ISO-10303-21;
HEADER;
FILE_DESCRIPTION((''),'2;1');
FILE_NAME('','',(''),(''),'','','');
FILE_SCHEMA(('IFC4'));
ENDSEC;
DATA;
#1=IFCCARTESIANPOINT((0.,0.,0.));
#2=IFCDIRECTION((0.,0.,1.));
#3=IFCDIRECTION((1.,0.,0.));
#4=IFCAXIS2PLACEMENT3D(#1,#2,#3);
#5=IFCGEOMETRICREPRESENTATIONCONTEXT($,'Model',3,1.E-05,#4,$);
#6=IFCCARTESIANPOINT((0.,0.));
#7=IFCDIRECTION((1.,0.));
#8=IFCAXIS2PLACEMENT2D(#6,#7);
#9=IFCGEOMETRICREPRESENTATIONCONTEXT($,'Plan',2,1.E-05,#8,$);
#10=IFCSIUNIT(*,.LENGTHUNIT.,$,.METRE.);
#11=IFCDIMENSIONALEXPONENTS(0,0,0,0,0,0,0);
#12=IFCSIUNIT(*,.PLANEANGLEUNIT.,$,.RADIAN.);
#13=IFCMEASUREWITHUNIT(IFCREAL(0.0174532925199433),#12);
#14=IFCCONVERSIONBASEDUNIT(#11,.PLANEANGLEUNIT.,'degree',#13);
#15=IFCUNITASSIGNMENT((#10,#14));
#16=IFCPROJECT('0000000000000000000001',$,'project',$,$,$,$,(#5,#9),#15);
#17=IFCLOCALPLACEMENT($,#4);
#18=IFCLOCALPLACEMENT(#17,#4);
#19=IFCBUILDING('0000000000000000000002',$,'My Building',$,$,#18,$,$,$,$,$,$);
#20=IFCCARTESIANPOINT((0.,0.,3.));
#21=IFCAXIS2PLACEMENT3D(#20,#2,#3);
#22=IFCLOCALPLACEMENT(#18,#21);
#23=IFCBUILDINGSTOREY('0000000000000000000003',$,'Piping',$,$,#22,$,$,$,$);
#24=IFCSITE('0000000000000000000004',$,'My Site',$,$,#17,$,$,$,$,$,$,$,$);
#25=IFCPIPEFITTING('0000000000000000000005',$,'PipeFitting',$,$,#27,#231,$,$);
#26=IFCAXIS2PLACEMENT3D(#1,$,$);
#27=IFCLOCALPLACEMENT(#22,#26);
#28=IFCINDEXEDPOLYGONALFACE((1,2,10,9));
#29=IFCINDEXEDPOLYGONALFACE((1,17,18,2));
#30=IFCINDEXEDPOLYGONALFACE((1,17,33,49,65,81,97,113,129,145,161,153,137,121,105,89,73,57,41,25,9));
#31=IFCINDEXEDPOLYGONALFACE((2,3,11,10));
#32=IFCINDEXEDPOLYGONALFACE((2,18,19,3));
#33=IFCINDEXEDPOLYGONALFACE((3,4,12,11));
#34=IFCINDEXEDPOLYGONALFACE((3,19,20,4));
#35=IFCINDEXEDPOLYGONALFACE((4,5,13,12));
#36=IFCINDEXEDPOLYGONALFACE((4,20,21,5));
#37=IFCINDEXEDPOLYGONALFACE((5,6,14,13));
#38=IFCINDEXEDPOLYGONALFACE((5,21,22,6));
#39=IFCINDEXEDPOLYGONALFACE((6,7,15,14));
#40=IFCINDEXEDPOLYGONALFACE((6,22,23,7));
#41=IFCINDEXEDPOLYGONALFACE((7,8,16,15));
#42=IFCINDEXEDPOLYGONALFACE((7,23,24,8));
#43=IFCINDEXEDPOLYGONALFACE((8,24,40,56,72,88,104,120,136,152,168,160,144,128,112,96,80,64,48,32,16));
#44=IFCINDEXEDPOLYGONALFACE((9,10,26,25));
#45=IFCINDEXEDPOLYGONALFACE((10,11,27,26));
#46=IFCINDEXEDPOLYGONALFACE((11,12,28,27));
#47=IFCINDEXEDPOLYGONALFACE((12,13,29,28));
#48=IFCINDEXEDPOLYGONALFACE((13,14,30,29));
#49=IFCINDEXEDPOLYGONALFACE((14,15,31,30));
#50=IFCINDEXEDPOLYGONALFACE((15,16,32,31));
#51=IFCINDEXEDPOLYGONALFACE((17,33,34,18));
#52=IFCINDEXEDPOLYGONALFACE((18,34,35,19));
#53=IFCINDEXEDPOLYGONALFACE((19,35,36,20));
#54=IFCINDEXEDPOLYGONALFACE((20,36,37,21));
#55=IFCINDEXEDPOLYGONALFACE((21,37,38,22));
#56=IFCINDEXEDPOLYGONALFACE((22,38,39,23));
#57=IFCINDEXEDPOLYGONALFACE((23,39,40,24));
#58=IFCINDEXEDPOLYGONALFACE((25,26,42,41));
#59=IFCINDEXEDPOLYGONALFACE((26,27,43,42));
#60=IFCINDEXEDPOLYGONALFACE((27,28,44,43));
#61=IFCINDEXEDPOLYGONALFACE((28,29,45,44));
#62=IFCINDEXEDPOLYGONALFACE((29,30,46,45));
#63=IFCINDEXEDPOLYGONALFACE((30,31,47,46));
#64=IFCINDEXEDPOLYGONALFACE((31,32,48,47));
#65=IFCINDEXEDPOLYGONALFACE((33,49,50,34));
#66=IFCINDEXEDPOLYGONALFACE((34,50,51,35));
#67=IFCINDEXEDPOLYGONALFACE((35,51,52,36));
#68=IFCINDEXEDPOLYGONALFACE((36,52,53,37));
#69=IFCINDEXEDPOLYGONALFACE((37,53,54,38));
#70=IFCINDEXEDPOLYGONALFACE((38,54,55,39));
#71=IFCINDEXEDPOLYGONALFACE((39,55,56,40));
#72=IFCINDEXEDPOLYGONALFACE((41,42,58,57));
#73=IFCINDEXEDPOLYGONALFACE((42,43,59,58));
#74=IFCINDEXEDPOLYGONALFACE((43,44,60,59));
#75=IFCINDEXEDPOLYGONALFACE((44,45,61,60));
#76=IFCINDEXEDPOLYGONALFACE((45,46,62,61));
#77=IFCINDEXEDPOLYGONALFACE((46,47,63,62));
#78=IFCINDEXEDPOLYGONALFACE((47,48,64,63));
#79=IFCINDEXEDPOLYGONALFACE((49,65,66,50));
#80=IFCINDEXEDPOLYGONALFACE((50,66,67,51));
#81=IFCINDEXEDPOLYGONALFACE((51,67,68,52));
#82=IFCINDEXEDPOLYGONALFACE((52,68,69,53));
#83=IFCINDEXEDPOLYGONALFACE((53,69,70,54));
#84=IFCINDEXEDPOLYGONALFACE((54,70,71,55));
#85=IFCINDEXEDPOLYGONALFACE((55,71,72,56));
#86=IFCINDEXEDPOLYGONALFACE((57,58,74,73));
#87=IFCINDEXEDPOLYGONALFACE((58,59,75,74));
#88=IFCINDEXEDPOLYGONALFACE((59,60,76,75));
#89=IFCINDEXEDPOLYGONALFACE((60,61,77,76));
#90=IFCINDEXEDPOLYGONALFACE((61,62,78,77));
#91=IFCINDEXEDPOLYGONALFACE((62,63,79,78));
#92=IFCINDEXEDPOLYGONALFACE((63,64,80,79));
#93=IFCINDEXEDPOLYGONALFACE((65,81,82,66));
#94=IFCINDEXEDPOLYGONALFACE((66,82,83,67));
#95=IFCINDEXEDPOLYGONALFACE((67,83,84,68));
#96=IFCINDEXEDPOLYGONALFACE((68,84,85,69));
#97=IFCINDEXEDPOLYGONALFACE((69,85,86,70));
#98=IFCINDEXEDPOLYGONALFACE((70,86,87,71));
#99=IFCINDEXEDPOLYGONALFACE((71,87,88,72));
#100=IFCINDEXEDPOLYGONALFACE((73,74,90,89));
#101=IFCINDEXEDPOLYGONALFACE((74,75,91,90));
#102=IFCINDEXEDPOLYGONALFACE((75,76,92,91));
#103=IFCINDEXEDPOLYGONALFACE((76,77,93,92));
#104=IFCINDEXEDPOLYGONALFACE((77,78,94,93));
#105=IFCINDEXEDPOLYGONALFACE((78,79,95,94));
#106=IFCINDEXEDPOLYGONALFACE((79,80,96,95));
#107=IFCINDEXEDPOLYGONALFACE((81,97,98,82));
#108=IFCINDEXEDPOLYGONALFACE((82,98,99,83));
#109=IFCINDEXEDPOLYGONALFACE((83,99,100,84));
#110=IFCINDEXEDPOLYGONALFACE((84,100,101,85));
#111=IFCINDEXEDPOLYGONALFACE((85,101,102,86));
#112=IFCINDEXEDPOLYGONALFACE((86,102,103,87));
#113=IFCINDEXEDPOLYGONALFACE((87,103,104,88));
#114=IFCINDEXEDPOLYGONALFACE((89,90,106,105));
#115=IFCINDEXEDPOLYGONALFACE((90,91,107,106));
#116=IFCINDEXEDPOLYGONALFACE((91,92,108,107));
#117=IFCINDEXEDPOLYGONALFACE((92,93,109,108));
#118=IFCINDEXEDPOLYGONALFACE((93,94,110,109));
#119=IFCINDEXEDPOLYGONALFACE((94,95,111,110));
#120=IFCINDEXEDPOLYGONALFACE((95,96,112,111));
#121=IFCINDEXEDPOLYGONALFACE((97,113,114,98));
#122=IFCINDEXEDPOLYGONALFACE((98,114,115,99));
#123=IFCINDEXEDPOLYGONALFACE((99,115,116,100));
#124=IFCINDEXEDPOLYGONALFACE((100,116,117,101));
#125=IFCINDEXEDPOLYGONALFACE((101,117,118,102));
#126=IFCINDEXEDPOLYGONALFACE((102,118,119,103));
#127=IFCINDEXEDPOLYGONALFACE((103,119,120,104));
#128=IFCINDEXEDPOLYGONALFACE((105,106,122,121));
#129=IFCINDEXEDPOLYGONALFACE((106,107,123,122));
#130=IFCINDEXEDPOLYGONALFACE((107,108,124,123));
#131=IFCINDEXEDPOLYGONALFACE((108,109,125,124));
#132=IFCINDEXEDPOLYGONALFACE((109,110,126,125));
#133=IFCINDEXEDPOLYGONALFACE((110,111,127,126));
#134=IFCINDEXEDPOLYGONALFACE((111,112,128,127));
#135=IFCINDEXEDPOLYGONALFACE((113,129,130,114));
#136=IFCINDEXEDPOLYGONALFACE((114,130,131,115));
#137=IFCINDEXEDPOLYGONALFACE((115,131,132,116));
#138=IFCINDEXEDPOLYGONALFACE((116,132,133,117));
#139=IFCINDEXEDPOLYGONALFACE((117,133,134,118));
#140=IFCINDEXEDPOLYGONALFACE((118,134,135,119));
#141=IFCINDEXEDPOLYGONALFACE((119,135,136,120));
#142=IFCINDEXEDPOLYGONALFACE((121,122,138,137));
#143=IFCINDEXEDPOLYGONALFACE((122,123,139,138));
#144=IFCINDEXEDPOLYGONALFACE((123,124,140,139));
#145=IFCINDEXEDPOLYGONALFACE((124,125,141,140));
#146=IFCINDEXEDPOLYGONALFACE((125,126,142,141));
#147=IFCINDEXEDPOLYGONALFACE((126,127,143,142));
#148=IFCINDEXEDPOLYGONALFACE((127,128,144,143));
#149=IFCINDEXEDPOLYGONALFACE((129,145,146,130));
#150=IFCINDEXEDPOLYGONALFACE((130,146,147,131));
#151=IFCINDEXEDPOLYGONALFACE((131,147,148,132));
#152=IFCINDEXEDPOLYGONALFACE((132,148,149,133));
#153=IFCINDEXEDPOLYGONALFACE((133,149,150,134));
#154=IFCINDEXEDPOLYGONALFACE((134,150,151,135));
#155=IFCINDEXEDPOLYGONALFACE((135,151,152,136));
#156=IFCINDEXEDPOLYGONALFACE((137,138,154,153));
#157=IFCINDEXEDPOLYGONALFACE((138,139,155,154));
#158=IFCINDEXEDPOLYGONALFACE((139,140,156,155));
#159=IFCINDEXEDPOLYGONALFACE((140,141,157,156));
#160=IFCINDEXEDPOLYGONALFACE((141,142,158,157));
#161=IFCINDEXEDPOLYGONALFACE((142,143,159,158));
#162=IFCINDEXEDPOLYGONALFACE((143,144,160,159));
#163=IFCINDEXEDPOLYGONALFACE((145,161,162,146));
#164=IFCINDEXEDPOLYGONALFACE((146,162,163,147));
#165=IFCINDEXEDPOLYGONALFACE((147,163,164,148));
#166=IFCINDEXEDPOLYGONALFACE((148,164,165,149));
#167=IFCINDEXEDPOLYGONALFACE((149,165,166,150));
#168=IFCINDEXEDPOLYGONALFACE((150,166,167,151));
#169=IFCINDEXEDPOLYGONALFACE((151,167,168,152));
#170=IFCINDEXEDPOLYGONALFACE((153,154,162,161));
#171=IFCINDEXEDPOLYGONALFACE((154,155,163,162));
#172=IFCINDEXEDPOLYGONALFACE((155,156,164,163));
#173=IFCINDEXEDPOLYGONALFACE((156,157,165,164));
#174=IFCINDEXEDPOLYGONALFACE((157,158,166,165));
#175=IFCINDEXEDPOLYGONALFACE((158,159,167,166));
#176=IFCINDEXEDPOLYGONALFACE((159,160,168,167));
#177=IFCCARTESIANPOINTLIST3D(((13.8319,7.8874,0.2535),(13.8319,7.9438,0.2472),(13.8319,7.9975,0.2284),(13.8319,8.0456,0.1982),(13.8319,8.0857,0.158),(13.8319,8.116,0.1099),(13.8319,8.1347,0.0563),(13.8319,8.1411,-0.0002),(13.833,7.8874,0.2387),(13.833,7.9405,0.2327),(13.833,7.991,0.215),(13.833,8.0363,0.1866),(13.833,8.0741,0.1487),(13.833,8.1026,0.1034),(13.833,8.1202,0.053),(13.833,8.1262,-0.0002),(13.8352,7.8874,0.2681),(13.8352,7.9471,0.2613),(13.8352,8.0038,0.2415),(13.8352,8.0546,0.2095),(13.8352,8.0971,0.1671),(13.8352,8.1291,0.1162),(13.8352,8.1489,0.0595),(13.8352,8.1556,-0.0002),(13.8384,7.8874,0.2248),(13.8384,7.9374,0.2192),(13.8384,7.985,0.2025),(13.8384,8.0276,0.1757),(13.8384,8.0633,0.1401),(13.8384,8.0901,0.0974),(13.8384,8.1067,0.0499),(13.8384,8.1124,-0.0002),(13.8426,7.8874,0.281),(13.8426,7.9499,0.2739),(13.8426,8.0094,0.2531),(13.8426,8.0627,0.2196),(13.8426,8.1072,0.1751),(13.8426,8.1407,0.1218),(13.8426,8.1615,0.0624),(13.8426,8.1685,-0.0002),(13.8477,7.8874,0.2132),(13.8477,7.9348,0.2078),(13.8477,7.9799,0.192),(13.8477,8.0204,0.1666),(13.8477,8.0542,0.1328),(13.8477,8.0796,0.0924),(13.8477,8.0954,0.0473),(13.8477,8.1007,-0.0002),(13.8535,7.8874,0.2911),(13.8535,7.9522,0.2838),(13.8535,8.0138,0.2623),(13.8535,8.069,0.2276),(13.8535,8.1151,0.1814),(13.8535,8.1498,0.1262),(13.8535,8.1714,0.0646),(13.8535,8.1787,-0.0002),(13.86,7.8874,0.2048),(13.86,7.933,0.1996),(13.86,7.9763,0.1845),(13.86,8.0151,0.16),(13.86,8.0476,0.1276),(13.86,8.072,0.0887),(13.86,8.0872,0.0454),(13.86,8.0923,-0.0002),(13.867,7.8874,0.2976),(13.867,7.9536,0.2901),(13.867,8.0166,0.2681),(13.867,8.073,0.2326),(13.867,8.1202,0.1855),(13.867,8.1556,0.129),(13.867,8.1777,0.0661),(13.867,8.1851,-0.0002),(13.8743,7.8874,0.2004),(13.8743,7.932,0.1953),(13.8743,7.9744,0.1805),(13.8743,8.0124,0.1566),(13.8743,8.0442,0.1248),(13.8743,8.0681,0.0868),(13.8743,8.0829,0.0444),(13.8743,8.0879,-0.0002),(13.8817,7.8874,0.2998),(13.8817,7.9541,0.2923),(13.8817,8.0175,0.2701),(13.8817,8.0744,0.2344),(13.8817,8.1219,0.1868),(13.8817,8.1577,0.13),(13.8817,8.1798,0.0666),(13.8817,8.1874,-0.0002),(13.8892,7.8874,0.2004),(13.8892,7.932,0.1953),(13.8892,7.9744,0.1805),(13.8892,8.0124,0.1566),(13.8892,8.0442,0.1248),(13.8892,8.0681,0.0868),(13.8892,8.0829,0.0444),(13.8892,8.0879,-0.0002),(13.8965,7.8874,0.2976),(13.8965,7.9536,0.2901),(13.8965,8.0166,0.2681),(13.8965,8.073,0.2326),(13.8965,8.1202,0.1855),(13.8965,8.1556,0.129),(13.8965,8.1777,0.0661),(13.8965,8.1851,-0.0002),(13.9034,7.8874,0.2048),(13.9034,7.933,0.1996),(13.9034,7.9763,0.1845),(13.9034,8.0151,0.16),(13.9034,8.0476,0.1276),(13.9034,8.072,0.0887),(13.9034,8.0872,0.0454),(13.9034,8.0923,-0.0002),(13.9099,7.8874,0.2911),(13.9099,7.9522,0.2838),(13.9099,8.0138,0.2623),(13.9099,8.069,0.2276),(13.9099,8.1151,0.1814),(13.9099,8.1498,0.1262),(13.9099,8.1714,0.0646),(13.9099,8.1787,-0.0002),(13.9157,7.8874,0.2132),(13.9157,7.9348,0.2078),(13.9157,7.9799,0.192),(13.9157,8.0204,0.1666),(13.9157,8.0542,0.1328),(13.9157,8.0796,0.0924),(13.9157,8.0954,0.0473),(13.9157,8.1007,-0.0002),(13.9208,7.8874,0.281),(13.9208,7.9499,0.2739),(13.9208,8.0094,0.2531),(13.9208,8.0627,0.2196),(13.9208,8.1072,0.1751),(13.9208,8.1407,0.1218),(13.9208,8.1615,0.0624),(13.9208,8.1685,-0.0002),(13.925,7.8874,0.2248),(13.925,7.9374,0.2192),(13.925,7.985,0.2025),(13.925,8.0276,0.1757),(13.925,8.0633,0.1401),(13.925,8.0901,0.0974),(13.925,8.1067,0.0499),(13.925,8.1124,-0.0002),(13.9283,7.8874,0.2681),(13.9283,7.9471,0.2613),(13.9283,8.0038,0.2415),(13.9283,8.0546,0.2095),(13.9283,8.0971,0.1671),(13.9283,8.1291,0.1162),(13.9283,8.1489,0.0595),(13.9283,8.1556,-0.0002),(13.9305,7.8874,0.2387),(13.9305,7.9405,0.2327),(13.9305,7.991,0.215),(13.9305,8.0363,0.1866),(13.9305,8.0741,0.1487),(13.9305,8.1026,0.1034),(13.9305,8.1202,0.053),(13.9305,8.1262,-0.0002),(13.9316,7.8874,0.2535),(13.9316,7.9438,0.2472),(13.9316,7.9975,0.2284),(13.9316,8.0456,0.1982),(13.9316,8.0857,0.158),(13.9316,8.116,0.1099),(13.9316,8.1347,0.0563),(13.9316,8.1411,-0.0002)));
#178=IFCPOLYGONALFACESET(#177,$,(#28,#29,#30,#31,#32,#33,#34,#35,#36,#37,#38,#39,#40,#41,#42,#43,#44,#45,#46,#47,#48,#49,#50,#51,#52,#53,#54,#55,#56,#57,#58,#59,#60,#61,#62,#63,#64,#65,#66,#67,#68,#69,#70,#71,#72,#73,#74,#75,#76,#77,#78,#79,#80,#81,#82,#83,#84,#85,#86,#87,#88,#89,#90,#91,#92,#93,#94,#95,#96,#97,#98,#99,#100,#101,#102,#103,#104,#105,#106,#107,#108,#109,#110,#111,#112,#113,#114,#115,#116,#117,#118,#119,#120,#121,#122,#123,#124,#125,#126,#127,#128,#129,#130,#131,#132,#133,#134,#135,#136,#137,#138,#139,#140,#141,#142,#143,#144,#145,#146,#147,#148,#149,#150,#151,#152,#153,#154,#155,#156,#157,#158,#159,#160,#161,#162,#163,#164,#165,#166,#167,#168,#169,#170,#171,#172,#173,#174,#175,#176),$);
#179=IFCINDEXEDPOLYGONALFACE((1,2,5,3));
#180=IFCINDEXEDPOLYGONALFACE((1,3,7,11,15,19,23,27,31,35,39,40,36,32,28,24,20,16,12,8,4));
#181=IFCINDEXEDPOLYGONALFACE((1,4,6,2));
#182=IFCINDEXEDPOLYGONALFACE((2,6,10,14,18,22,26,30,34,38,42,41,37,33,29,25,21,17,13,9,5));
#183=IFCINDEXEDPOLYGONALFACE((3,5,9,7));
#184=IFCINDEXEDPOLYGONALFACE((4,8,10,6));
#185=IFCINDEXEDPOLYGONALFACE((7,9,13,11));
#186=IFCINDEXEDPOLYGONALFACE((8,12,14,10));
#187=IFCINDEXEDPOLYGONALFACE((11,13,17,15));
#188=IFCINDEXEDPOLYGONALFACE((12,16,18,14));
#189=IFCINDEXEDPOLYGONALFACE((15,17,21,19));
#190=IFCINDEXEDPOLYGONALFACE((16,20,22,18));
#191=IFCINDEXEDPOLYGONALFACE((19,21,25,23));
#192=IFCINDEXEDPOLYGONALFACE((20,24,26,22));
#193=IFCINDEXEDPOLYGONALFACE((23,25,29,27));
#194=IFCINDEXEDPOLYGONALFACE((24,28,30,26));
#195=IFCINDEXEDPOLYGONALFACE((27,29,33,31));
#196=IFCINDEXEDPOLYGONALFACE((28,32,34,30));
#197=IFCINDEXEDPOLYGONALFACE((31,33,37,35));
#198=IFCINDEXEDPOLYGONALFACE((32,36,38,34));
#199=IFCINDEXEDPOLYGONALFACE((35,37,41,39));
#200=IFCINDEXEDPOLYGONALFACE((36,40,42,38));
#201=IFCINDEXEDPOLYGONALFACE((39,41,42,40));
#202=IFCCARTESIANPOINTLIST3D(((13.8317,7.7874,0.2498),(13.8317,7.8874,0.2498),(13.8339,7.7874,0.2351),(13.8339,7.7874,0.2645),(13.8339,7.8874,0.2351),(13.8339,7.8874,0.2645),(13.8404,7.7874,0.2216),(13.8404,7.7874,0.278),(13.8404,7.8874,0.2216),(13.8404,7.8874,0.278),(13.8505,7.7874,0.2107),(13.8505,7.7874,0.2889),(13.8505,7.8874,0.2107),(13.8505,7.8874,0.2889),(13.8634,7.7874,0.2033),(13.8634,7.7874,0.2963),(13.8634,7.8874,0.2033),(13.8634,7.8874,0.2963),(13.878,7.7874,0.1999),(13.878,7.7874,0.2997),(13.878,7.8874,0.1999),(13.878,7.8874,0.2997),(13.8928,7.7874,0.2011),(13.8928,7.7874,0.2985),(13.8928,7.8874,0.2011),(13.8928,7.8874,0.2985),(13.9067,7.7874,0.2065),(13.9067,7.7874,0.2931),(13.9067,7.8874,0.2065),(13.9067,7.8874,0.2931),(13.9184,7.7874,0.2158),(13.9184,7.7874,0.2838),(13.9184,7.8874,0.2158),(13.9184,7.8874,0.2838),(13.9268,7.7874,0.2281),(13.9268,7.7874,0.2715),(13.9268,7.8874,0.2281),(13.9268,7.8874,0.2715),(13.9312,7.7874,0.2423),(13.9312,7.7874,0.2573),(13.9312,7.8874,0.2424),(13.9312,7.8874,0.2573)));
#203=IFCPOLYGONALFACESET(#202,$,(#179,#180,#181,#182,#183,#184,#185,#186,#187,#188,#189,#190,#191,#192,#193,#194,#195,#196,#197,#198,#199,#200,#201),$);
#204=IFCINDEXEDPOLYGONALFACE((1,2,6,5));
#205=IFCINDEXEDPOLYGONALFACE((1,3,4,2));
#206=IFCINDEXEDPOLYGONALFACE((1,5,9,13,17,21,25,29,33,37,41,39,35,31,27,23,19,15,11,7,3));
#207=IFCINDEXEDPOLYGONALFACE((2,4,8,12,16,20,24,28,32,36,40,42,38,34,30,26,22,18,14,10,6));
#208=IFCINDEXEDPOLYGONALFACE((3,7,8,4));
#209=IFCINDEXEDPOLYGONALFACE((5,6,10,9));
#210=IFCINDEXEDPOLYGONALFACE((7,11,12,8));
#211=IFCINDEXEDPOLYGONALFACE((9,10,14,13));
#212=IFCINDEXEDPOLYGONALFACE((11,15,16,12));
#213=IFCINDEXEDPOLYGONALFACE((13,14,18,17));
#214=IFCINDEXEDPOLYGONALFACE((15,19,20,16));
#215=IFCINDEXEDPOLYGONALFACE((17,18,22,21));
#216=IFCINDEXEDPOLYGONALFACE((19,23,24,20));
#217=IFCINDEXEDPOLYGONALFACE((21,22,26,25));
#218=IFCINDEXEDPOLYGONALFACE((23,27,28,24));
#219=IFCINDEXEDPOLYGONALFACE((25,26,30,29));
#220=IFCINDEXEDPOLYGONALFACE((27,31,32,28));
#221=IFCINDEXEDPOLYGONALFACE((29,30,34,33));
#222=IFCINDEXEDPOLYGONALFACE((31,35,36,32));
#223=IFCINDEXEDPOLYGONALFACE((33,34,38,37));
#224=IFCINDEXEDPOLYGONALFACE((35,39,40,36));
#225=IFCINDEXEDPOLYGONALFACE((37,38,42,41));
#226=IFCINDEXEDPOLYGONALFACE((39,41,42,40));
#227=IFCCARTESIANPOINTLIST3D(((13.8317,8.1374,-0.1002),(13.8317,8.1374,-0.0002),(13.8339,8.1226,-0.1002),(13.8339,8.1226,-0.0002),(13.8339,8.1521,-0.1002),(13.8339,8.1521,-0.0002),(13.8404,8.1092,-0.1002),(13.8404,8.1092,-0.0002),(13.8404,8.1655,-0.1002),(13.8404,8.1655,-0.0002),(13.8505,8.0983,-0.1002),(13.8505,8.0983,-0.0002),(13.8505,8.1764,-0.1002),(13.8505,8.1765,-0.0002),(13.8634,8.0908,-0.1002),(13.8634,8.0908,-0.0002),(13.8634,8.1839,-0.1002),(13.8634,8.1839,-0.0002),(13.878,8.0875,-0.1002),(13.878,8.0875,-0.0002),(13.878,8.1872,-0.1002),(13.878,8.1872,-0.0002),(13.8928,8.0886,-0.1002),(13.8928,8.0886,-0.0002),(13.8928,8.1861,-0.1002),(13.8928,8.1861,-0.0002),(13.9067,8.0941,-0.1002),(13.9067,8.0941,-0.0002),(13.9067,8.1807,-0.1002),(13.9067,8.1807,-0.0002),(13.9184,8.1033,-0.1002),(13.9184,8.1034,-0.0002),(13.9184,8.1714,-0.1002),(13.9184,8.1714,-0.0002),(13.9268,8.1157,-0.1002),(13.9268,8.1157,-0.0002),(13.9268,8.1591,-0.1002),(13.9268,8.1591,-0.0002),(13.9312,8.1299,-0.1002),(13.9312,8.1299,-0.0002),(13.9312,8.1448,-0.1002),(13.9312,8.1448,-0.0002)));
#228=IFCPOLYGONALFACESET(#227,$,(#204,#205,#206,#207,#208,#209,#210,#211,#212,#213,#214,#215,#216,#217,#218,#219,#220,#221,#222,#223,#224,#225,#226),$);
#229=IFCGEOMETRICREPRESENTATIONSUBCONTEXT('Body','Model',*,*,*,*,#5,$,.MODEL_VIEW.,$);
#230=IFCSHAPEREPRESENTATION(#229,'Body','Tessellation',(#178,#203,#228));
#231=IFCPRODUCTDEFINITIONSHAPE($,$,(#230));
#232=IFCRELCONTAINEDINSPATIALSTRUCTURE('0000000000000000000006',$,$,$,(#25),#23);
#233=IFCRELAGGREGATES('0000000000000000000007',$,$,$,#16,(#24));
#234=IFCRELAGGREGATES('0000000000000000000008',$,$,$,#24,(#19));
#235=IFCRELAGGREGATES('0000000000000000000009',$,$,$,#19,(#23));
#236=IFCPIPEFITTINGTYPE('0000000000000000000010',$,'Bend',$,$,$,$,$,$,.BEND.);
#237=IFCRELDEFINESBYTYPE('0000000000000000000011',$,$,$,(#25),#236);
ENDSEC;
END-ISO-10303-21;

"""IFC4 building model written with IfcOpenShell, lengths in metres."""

from ifc_helpers import new_model, entity, si_unit, converted_unit, frame, origin_with_axes, origin_2d_with_axis, place, context, subcontext, project, spatial, circle, extrude, source, transform, mapped, type_object, type_shapes, element, save


model = new_model("IFC4")

# Units and contexts
model_context = context("Model", 3, precision=1e-05, world=origin_with_axes())
plan_context = context("Plan", 2, precision=1e-05, world=origin_2d_with_axis())
body_context = subcontext(model_context, "Body", "Model", "MODEL_VIEW")
ifc_project = project(units=[si_unit("LENGTHUNIT", "METRE"), converted_unit("PLANEANGLEUNIT", "degree", entity("IfcReal", 0.0174532925199433), si_unit("PLANEANGLEUNIT", "RADIAN"), dimensions=[0, 0, 0, 0, 0, 0, 0])], contexts=[model_context, plan_context])

# Site, building, storey
site_placement = place(None, origin_with_axes())
site = spatial("IfcSite", under=ifc_project, at=site_placement, Name="My Site")
building_placement = place(site_placement, origin_with_axes())
building = spatial("IfcBuilding", under=site, at=building_placement, Name="My Building")
storey_placement = place(building_placement, frame((0.0, 0.0, 3.0), z_axis=(0.0, 0.0, 1.0), x_axis=(1.0, 0.0, 0.0)))
storey = spatial("IfcBuildingStorey", under=building, at=storey_placement, Name="Piping")

# Pipe fitting
pipe_fitting_type_1 = type_object("IfcPipeFittingType", Name="Bend", PredefinedType="BEND")
shared_shape = source(origin_with_axes(), body_context, "Body", "SolidModel", [
    entity("IfcSweptDiskSolid", entity("IfcIndexedPolyCurve", entity("IfcCartesianPointList3D", [[0.0, 0.0, 0.1], [0.0, -0.0732, 0.2768], [0.0, -0.25, 0.35]]), [entity("IfcArcIndex", [1, 2, 3])]), 0.05),
    extrude(circle(Radius=0.05), origin_with_axes(), (0.0, 0.0, 1.0), 0.1),
    extrude(circle(Radius=0.05), frame((0.0, -0.25, 0.35), z_axis=(0.0, -1.0, -0.00003), x_axis=(1.0, 0.0, 0.0)), (0.0, 0.0, 1.0), 0.1),
])
type_shapes(pipe_fitting_type_1, [shared_shape])
for number, where, z_axis, x_axis, name in (
    (1, (13.8817, 7.7874, 0.2498), (0.0, 1.0, 0.000008), (-1.0, 0.0, 0.0), "PipeFitting"),
):
    element("IfcPipeFitting", number, at=place(storey_placement, frame(where, z_axis=z_axis, x_axis=x_axis)), inside=storey, type_object=pipe_fitting_type_1, Name=name, context=body_context, shape_type="MappedRepresentation", body=[
        mapped(shared_shape, transform((0.0, 0.0, 0.0), x_axis=(1.0, 0.0, 0.0), y_axis=(0.0, 1.0, 0.0), z_axis=(0.0, 0.0, 1.0), scale=1.0)),
    ])

save(model, "model.ifc")
